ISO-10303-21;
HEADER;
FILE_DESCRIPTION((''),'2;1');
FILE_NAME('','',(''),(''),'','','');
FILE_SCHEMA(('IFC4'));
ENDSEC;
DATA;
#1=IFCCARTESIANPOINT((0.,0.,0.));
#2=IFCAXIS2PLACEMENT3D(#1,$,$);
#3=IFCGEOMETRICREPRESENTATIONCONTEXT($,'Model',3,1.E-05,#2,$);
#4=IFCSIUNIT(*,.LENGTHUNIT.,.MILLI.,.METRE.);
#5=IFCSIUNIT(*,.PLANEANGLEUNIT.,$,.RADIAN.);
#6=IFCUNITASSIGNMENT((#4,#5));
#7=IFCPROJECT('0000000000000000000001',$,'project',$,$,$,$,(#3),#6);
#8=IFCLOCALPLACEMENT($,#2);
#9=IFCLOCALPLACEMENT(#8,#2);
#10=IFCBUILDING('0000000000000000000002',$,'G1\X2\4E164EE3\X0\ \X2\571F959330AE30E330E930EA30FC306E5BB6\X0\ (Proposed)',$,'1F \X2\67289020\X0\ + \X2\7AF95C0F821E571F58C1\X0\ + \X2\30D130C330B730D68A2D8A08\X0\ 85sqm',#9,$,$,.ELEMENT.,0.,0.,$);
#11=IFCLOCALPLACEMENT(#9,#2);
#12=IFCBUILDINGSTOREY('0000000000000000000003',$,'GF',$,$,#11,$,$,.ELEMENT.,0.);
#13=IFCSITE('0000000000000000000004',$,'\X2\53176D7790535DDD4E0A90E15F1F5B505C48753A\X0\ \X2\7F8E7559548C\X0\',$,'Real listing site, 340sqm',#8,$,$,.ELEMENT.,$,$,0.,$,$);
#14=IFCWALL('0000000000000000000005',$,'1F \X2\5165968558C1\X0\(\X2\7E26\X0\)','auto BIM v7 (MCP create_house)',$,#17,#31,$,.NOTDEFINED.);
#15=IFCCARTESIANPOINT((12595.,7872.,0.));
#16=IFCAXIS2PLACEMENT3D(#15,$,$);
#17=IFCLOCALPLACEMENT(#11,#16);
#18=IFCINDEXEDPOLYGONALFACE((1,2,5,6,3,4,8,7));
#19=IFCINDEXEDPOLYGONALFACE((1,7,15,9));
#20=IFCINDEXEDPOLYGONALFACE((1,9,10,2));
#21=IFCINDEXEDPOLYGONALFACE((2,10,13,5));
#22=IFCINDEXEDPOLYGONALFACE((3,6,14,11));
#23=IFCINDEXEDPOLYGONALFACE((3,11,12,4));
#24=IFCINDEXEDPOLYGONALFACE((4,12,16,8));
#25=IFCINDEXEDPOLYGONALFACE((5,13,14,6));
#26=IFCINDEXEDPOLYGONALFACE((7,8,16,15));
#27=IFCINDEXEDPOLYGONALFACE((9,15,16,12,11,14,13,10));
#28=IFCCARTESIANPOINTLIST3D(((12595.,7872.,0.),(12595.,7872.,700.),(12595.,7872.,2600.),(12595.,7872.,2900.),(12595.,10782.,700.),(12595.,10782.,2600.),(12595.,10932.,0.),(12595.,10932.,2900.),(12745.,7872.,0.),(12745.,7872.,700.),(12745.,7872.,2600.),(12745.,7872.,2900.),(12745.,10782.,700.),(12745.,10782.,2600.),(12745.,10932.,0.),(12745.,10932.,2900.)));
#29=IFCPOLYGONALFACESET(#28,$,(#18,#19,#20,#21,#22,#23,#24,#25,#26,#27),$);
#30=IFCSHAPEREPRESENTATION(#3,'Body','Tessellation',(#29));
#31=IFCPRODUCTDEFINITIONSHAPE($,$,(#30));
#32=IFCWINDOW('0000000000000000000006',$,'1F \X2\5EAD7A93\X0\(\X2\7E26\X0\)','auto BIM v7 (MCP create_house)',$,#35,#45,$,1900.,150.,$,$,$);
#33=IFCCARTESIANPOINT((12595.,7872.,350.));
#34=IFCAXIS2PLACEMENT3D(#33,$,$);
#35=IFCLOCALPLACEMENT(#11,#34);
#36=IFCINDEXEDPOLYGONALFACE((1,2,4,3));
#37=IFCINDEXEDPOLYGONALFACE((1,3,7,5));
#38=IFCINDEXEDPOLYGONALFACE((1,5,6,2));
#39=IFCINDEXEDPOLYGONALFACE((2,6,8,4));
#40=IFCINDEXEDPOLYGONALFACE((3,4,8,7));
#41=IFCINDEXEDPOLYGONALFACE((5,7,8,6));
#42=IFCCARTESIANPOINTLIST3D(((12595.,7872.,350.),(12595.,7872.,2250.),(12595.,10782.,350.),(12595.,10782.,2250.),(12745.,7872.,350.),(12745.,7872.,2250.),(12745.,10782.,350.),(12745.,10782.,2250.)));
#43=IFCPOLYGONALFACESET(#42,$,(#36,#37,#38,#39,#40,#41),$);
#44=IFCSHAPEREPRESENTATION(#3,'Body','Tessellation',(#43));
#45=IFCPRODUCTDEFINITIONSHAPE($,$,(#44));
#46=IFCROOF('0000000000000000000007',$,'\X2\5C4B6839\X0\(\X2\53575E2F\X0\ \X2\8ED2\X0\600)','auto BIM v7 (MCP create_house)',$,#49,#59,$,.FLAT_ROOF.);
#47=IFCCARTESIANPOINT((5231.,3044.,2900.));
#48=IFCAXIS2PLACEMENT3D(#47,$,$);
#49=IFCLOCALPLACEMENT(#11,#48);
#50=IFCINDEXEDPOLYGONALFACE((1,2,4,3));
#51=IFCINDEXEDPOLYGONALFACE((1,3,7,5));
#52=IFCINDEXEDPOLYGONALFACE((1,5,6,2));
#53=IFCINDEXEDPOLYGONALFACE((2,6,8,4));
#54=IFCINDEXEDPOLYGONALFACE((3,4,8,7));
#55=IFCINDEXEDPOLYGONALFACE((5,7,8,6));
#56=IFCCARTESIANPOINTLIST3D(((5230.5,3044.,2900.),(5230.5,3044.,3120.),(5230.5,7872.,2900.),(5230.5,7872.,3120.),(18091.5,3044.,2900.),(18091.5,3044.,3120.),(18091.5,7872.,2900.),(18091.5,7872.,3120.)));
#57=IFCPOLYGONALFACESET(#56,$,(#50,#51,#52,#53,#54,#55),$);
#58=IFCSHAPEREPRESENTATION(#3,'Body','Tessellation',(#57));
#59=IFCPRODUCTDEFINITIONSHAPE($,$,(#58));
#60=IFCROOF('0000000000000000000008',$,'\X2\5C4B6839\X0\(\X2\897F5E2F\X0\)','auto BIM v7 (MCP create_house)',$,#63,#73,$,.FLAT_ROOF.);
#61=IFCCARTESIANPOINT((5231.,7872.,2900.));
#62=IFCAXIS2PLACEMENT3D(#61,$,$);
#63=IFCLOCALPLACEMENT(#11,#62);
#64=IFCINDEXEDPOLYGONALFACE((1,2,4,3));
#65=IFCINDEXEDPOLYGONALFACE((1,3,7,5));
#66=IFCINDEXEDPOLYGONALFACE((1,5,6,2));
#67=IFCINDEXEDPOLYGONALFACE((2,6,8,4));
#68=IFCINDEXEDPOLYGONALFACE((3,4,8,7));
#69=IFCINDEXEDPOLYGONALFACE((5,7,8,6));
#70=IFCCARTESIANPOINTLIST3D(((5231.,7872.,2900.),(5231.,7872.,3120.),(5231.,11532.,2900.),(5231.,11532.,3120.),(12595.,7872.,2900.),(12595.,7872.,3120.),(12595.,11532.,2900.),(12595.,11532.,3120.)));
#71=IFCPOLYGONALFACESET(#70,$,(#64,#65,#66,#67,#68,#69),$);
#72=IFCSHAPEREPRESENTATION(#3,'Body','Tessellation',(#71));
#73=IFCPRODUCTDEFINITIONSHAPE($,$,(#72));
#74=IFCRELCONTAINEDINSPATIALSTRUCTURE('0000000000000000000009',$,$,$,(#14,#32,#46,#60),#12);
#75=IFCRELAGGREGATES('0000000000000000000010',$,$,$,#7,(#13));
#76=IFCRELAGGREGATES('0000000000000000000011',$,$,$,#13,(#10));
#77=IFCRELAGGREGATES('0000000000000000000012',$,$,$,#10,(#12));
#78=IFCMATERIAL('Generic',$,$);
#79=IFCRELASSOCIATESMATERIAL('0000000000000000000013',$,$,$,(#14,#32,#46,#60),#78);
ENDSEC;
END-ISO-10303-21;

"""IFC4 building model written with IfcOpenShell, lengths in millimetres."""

from ifc_helpers import new_model, si_unit, frame, frame_2d, origin, place, context, project, spatial, rectangle, extrude, material, element, fill, save


model = new_model("IFC4")

# Units and contexts
model_context = context("Model", 3, precision=1e-05, world=origin())
ifc_project = project(units=[si_unit("LENGTHUNIT", "METRE", prefix="MILLI"), si_unit("PLANEANGLEUNIT", "RADIAN")], contexts=[model_context])

# Site, building, storey
site_placement = place(None, origin())
site = spatial("IfcSite", under=ifc_project, at=site_placement, Name="北海道川上郡弟子屈町 美留和", ObjectType="Real listing site, 340sqm", CompositionType="ELEMENT", RefElevation=0.0)
building_placement = place(site_placement, origin())
building = spatial("IfcBuilding", under=site, at=building_placement, Name="G1世代 土間ギャラリーの家 (Proposed)", ObjectType="1F 木造 + 竹小舞土壁 + パッシブ設計 85sqm", CompositionType="ELEMENT", ElevationOfRefHeight=0.0, ElevationOfTerrain=0.0)
storey_placement = place(building_placement, origin())
storey = spatial("IfcBuildingStorey", under=building, at=storey_placement, Name="GF", CompositionType="ELEMENT", Elevation=0.0)

# Shared definitions
ifc_material = material(Name="Generic")

# Wall, opening, window
wall_1_placement = place(storey_placement, frame((12595.0, 7872.0, 0.0)))
wall_1 = element("IfcWall", 1, at=wall_1_placement, inside=storey, material=ifc_material, Name="1F 入隅壁(縦)", Description="auto BIM v7 (MCP create_house)", PredefinedType="NOTDEFINED", context=model_context, shape_type="SweptSolid", body=[
    extrude(rectangle(XDim=150.0, YDim=3060.0, at=frame_2d((75.0, 1530.0))), frame((12595.0, 7872.0, 0.0)), (0.0, 0.0, 1.0), 2900.0),
])
opening_1_placement = place(storey_placement, frame((12595.0, 7872.0, 350.0)))
opening_1 = element("IfcOpeningElement", 2, at=opening_1_placement, cuts=wall_1, PredefinedType="NOTDEFINED", context=model_context, shape_type="SweptSolid", body=[
    extrude(rectangle(XDim=150.0, YDim=2910.0, at=frame_2d((75.0, 1455.0))), frame((12595.0, 7872.0, 350.0)), (0.0, 0.0, 1.0), 1900.0),
])
window_1_placement = place(storey_placement, frame((12595.0, 7872.0, 350.0)))
window_1 = element("IfcWindow", 3, at=window_1_placement, inside=storey, material=ifc_material, Name="1F 庭窓(縦)", Description="auto BIM v7 (MCP create_house)", OverallHeight=1900.0, OverallWidth=150.0, context=model_context, shape_type="SweptSolid", body=[
    extrude(rectangle(XDim=150.0, YDim=2910.0, at=frame_2d((75.0, 1455.0))), frame((12595.0, 7872.0, 350.0)), (0.0, 0.0, 1.0), 1900.0),
])
fill(opening_1, window_1)

# Roofs
roof_1_placement = place(storey_placement, frame((5231.0, 3044.0, 2900.0)))
element("IfcRoof", 4, at=roof_1_placement, inside=storey, material=ifc_material, Name="屋根(南帯 軒600)", Description="auto BIM v7 (MCP create_house)", PredefinedType="FLAT_ROOF", context=model_context, shape_type="SweptSolid", body=[
    extrude(rectangle(XDim=12861.0, YDim=4828.0, at=frame_2d((6430.0, 2414.0))), frame((5231.0, 3044.0, 2900.0)), (0.0, 0.0, 1.0), 220.0),
])
roof_2_placement = place(storey_placement, frame((5231.0, 7872.0, 2900.0)))
element("IfcRoof", 5, at=roof_2_placement, inside=storey, material=ifc_material, Name="屋根(西帯)", Description="auto BIM v7 (MCP create_house)", PredefinedType="FLAT_ROOF", context=model_context, shape_type="SweptSolid", body=[
    extrude(rectangle(XDim=7364.0, YDim=3660.0, at=frame_2d((3682.0, 1830.0))), frame((5231.0, 7872.0, 2900.0)), (0.0, 0.0, 1.0), 220.0),
])

save(model, "model.ifc")
